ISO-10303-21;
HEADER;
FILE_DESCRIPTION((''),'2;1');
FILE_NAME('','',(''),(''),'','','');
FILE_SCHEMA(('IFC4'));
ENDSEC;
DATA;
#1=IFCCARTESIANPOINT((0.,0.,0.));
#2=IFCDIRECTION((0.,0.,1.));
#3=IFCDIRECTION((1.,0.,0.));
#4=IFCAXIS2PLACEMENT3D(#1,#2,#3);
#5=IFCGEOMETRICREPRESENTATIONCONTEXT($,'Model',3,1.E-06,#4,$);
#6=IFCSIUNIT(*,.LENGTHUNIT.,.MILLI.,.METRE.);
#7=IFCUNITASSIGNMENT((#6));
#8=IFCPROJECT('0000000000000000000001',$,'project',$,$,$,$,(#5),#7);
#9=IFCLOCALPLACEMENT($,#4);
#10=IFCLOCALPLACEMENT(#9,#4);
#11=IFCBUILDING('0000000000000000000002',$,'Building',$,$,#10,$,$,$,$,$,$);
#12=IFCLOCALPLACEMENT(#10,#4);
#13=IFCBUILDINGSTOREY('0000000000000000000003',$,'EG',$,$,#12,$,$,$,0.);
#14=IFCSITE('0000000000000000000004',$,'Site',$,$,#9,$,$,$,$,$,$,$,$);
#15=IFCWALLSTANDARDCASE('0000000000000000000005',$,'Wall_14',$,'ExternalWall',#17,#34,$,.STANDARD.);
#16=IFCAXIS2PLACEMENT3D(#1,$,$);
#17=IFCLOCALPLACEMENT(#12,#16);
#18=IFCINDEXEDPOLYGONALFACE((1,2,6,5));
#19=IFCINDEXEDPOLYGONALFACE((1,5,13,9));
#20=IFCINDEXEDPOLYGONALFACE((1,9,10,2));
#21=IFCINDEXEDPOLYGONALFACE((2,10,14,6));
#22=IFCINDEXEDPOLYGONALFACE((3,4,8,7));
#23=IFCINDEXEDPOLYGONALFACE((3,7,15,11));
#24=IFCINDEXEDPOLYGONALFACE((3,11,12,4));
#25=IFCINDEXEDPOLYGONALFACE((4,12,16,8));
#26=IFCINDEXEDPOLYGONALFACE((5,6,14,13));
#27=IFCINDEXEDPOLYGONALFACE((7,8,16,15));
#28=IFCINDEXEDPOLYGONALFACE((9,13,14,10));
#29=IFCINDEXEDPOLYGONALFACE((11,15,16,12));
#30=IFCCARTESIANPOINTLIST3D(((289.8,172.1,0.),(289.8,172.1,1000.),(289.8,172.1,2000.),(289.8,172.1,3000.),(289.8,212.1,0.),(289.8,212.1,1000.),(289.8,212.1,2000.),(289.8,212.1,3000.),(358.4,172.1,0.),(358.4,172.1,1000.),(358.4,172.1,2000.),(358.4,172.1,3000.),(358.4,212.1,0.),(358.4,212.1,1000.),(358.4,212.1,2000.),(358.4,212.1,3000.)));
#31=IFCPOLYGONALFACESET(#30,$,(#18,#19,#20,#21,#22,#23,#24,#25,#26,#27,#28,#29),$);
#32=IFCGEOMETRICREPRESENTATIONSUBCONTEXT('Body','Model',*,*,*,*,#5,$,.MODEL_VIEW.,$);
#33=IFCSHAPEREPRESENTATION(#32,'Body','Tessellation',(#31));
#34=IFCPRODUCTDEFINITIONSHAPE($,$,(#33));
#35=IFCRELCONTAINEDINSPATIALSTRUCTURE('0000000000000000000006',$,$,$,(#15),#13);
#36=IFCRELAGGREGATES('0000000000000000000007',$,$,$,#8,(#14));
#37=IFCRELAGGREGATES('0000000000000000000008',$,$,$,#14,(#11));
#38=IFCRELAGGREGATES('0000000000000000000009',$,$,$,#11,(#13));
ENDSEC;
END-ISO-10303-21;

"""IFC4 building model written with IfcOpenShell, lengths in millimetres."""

from ifc_helpers import new_model, si_unit, frame, origin_with_axes, place, context, subcontext, project, spatial, rectangle, extrude, element, save


model = new_model("IFC4")

# Units and contexts
model_context = context("Model", 3, precision=1e-06, world=origin_with_axes())
body_context = subcontext(model_context, "Body", "Model", "MODEL_VIEW")
ifc_project = project(units=[si_unit("LENGTHUNIT", "METRE", prefix="MILLI")], contexts=[model_context])

# Site, building, storey
site_placement = place(None, origin_with_axes())
site = spatial("IfcSite", under=ifc_project, at=site_placement, Name="Site")
building_placement = place(site_placement, origin_with_axes())
building = spatial("IfcBuilding", under=site, at=building_placement, Name="Building")
storey_placement = place(building_placement, origin_with_axes())
storey = spatial("IfcBuildingStorey", under=building, at=storey_placement, Name="EG", Elevation=0.0)

# Wall, opening
wall_1_placement = place(storey_placement, origin_with_axes())
wall_1 = element("IfcWallStandardCase", 1, at=wall_1_placement, inside=storey, Name="Wall_14", ObjectType="ExternalWall", PredefinedType="STANDARD", context=body_context, shape_type="SweptSolid", body=[
    extrude(rectangle(XDim=68.6, YDim=40.0), frame((324.1, 192.1, 0.0), z_axis=(0.0, 0.0, 1.0), x_axis=(-1.0, 0.0, 0.0)), (0.0, 0.0, 1.0), 3000.0),
])
opening_1_placement = place(wall_1_placement, origin_with_axes())
element("IfcOpeningElement", 2, at=opening_1_placement, inside=storey, cuts=wall_1, context=body_context, shape_type="SweptSolid", body=[
    extrude(rectangle(XDim=1200.0, YDim=40.0), frame((383.1, 192.1, 1000.0), z_axis=(0.0, 0.0, 1.0), x_axis=(-1.0, 0.0, 0.0)), (0.0, 0.0, 1.0), 1000.0),
])

save(model, "model.ifc")
